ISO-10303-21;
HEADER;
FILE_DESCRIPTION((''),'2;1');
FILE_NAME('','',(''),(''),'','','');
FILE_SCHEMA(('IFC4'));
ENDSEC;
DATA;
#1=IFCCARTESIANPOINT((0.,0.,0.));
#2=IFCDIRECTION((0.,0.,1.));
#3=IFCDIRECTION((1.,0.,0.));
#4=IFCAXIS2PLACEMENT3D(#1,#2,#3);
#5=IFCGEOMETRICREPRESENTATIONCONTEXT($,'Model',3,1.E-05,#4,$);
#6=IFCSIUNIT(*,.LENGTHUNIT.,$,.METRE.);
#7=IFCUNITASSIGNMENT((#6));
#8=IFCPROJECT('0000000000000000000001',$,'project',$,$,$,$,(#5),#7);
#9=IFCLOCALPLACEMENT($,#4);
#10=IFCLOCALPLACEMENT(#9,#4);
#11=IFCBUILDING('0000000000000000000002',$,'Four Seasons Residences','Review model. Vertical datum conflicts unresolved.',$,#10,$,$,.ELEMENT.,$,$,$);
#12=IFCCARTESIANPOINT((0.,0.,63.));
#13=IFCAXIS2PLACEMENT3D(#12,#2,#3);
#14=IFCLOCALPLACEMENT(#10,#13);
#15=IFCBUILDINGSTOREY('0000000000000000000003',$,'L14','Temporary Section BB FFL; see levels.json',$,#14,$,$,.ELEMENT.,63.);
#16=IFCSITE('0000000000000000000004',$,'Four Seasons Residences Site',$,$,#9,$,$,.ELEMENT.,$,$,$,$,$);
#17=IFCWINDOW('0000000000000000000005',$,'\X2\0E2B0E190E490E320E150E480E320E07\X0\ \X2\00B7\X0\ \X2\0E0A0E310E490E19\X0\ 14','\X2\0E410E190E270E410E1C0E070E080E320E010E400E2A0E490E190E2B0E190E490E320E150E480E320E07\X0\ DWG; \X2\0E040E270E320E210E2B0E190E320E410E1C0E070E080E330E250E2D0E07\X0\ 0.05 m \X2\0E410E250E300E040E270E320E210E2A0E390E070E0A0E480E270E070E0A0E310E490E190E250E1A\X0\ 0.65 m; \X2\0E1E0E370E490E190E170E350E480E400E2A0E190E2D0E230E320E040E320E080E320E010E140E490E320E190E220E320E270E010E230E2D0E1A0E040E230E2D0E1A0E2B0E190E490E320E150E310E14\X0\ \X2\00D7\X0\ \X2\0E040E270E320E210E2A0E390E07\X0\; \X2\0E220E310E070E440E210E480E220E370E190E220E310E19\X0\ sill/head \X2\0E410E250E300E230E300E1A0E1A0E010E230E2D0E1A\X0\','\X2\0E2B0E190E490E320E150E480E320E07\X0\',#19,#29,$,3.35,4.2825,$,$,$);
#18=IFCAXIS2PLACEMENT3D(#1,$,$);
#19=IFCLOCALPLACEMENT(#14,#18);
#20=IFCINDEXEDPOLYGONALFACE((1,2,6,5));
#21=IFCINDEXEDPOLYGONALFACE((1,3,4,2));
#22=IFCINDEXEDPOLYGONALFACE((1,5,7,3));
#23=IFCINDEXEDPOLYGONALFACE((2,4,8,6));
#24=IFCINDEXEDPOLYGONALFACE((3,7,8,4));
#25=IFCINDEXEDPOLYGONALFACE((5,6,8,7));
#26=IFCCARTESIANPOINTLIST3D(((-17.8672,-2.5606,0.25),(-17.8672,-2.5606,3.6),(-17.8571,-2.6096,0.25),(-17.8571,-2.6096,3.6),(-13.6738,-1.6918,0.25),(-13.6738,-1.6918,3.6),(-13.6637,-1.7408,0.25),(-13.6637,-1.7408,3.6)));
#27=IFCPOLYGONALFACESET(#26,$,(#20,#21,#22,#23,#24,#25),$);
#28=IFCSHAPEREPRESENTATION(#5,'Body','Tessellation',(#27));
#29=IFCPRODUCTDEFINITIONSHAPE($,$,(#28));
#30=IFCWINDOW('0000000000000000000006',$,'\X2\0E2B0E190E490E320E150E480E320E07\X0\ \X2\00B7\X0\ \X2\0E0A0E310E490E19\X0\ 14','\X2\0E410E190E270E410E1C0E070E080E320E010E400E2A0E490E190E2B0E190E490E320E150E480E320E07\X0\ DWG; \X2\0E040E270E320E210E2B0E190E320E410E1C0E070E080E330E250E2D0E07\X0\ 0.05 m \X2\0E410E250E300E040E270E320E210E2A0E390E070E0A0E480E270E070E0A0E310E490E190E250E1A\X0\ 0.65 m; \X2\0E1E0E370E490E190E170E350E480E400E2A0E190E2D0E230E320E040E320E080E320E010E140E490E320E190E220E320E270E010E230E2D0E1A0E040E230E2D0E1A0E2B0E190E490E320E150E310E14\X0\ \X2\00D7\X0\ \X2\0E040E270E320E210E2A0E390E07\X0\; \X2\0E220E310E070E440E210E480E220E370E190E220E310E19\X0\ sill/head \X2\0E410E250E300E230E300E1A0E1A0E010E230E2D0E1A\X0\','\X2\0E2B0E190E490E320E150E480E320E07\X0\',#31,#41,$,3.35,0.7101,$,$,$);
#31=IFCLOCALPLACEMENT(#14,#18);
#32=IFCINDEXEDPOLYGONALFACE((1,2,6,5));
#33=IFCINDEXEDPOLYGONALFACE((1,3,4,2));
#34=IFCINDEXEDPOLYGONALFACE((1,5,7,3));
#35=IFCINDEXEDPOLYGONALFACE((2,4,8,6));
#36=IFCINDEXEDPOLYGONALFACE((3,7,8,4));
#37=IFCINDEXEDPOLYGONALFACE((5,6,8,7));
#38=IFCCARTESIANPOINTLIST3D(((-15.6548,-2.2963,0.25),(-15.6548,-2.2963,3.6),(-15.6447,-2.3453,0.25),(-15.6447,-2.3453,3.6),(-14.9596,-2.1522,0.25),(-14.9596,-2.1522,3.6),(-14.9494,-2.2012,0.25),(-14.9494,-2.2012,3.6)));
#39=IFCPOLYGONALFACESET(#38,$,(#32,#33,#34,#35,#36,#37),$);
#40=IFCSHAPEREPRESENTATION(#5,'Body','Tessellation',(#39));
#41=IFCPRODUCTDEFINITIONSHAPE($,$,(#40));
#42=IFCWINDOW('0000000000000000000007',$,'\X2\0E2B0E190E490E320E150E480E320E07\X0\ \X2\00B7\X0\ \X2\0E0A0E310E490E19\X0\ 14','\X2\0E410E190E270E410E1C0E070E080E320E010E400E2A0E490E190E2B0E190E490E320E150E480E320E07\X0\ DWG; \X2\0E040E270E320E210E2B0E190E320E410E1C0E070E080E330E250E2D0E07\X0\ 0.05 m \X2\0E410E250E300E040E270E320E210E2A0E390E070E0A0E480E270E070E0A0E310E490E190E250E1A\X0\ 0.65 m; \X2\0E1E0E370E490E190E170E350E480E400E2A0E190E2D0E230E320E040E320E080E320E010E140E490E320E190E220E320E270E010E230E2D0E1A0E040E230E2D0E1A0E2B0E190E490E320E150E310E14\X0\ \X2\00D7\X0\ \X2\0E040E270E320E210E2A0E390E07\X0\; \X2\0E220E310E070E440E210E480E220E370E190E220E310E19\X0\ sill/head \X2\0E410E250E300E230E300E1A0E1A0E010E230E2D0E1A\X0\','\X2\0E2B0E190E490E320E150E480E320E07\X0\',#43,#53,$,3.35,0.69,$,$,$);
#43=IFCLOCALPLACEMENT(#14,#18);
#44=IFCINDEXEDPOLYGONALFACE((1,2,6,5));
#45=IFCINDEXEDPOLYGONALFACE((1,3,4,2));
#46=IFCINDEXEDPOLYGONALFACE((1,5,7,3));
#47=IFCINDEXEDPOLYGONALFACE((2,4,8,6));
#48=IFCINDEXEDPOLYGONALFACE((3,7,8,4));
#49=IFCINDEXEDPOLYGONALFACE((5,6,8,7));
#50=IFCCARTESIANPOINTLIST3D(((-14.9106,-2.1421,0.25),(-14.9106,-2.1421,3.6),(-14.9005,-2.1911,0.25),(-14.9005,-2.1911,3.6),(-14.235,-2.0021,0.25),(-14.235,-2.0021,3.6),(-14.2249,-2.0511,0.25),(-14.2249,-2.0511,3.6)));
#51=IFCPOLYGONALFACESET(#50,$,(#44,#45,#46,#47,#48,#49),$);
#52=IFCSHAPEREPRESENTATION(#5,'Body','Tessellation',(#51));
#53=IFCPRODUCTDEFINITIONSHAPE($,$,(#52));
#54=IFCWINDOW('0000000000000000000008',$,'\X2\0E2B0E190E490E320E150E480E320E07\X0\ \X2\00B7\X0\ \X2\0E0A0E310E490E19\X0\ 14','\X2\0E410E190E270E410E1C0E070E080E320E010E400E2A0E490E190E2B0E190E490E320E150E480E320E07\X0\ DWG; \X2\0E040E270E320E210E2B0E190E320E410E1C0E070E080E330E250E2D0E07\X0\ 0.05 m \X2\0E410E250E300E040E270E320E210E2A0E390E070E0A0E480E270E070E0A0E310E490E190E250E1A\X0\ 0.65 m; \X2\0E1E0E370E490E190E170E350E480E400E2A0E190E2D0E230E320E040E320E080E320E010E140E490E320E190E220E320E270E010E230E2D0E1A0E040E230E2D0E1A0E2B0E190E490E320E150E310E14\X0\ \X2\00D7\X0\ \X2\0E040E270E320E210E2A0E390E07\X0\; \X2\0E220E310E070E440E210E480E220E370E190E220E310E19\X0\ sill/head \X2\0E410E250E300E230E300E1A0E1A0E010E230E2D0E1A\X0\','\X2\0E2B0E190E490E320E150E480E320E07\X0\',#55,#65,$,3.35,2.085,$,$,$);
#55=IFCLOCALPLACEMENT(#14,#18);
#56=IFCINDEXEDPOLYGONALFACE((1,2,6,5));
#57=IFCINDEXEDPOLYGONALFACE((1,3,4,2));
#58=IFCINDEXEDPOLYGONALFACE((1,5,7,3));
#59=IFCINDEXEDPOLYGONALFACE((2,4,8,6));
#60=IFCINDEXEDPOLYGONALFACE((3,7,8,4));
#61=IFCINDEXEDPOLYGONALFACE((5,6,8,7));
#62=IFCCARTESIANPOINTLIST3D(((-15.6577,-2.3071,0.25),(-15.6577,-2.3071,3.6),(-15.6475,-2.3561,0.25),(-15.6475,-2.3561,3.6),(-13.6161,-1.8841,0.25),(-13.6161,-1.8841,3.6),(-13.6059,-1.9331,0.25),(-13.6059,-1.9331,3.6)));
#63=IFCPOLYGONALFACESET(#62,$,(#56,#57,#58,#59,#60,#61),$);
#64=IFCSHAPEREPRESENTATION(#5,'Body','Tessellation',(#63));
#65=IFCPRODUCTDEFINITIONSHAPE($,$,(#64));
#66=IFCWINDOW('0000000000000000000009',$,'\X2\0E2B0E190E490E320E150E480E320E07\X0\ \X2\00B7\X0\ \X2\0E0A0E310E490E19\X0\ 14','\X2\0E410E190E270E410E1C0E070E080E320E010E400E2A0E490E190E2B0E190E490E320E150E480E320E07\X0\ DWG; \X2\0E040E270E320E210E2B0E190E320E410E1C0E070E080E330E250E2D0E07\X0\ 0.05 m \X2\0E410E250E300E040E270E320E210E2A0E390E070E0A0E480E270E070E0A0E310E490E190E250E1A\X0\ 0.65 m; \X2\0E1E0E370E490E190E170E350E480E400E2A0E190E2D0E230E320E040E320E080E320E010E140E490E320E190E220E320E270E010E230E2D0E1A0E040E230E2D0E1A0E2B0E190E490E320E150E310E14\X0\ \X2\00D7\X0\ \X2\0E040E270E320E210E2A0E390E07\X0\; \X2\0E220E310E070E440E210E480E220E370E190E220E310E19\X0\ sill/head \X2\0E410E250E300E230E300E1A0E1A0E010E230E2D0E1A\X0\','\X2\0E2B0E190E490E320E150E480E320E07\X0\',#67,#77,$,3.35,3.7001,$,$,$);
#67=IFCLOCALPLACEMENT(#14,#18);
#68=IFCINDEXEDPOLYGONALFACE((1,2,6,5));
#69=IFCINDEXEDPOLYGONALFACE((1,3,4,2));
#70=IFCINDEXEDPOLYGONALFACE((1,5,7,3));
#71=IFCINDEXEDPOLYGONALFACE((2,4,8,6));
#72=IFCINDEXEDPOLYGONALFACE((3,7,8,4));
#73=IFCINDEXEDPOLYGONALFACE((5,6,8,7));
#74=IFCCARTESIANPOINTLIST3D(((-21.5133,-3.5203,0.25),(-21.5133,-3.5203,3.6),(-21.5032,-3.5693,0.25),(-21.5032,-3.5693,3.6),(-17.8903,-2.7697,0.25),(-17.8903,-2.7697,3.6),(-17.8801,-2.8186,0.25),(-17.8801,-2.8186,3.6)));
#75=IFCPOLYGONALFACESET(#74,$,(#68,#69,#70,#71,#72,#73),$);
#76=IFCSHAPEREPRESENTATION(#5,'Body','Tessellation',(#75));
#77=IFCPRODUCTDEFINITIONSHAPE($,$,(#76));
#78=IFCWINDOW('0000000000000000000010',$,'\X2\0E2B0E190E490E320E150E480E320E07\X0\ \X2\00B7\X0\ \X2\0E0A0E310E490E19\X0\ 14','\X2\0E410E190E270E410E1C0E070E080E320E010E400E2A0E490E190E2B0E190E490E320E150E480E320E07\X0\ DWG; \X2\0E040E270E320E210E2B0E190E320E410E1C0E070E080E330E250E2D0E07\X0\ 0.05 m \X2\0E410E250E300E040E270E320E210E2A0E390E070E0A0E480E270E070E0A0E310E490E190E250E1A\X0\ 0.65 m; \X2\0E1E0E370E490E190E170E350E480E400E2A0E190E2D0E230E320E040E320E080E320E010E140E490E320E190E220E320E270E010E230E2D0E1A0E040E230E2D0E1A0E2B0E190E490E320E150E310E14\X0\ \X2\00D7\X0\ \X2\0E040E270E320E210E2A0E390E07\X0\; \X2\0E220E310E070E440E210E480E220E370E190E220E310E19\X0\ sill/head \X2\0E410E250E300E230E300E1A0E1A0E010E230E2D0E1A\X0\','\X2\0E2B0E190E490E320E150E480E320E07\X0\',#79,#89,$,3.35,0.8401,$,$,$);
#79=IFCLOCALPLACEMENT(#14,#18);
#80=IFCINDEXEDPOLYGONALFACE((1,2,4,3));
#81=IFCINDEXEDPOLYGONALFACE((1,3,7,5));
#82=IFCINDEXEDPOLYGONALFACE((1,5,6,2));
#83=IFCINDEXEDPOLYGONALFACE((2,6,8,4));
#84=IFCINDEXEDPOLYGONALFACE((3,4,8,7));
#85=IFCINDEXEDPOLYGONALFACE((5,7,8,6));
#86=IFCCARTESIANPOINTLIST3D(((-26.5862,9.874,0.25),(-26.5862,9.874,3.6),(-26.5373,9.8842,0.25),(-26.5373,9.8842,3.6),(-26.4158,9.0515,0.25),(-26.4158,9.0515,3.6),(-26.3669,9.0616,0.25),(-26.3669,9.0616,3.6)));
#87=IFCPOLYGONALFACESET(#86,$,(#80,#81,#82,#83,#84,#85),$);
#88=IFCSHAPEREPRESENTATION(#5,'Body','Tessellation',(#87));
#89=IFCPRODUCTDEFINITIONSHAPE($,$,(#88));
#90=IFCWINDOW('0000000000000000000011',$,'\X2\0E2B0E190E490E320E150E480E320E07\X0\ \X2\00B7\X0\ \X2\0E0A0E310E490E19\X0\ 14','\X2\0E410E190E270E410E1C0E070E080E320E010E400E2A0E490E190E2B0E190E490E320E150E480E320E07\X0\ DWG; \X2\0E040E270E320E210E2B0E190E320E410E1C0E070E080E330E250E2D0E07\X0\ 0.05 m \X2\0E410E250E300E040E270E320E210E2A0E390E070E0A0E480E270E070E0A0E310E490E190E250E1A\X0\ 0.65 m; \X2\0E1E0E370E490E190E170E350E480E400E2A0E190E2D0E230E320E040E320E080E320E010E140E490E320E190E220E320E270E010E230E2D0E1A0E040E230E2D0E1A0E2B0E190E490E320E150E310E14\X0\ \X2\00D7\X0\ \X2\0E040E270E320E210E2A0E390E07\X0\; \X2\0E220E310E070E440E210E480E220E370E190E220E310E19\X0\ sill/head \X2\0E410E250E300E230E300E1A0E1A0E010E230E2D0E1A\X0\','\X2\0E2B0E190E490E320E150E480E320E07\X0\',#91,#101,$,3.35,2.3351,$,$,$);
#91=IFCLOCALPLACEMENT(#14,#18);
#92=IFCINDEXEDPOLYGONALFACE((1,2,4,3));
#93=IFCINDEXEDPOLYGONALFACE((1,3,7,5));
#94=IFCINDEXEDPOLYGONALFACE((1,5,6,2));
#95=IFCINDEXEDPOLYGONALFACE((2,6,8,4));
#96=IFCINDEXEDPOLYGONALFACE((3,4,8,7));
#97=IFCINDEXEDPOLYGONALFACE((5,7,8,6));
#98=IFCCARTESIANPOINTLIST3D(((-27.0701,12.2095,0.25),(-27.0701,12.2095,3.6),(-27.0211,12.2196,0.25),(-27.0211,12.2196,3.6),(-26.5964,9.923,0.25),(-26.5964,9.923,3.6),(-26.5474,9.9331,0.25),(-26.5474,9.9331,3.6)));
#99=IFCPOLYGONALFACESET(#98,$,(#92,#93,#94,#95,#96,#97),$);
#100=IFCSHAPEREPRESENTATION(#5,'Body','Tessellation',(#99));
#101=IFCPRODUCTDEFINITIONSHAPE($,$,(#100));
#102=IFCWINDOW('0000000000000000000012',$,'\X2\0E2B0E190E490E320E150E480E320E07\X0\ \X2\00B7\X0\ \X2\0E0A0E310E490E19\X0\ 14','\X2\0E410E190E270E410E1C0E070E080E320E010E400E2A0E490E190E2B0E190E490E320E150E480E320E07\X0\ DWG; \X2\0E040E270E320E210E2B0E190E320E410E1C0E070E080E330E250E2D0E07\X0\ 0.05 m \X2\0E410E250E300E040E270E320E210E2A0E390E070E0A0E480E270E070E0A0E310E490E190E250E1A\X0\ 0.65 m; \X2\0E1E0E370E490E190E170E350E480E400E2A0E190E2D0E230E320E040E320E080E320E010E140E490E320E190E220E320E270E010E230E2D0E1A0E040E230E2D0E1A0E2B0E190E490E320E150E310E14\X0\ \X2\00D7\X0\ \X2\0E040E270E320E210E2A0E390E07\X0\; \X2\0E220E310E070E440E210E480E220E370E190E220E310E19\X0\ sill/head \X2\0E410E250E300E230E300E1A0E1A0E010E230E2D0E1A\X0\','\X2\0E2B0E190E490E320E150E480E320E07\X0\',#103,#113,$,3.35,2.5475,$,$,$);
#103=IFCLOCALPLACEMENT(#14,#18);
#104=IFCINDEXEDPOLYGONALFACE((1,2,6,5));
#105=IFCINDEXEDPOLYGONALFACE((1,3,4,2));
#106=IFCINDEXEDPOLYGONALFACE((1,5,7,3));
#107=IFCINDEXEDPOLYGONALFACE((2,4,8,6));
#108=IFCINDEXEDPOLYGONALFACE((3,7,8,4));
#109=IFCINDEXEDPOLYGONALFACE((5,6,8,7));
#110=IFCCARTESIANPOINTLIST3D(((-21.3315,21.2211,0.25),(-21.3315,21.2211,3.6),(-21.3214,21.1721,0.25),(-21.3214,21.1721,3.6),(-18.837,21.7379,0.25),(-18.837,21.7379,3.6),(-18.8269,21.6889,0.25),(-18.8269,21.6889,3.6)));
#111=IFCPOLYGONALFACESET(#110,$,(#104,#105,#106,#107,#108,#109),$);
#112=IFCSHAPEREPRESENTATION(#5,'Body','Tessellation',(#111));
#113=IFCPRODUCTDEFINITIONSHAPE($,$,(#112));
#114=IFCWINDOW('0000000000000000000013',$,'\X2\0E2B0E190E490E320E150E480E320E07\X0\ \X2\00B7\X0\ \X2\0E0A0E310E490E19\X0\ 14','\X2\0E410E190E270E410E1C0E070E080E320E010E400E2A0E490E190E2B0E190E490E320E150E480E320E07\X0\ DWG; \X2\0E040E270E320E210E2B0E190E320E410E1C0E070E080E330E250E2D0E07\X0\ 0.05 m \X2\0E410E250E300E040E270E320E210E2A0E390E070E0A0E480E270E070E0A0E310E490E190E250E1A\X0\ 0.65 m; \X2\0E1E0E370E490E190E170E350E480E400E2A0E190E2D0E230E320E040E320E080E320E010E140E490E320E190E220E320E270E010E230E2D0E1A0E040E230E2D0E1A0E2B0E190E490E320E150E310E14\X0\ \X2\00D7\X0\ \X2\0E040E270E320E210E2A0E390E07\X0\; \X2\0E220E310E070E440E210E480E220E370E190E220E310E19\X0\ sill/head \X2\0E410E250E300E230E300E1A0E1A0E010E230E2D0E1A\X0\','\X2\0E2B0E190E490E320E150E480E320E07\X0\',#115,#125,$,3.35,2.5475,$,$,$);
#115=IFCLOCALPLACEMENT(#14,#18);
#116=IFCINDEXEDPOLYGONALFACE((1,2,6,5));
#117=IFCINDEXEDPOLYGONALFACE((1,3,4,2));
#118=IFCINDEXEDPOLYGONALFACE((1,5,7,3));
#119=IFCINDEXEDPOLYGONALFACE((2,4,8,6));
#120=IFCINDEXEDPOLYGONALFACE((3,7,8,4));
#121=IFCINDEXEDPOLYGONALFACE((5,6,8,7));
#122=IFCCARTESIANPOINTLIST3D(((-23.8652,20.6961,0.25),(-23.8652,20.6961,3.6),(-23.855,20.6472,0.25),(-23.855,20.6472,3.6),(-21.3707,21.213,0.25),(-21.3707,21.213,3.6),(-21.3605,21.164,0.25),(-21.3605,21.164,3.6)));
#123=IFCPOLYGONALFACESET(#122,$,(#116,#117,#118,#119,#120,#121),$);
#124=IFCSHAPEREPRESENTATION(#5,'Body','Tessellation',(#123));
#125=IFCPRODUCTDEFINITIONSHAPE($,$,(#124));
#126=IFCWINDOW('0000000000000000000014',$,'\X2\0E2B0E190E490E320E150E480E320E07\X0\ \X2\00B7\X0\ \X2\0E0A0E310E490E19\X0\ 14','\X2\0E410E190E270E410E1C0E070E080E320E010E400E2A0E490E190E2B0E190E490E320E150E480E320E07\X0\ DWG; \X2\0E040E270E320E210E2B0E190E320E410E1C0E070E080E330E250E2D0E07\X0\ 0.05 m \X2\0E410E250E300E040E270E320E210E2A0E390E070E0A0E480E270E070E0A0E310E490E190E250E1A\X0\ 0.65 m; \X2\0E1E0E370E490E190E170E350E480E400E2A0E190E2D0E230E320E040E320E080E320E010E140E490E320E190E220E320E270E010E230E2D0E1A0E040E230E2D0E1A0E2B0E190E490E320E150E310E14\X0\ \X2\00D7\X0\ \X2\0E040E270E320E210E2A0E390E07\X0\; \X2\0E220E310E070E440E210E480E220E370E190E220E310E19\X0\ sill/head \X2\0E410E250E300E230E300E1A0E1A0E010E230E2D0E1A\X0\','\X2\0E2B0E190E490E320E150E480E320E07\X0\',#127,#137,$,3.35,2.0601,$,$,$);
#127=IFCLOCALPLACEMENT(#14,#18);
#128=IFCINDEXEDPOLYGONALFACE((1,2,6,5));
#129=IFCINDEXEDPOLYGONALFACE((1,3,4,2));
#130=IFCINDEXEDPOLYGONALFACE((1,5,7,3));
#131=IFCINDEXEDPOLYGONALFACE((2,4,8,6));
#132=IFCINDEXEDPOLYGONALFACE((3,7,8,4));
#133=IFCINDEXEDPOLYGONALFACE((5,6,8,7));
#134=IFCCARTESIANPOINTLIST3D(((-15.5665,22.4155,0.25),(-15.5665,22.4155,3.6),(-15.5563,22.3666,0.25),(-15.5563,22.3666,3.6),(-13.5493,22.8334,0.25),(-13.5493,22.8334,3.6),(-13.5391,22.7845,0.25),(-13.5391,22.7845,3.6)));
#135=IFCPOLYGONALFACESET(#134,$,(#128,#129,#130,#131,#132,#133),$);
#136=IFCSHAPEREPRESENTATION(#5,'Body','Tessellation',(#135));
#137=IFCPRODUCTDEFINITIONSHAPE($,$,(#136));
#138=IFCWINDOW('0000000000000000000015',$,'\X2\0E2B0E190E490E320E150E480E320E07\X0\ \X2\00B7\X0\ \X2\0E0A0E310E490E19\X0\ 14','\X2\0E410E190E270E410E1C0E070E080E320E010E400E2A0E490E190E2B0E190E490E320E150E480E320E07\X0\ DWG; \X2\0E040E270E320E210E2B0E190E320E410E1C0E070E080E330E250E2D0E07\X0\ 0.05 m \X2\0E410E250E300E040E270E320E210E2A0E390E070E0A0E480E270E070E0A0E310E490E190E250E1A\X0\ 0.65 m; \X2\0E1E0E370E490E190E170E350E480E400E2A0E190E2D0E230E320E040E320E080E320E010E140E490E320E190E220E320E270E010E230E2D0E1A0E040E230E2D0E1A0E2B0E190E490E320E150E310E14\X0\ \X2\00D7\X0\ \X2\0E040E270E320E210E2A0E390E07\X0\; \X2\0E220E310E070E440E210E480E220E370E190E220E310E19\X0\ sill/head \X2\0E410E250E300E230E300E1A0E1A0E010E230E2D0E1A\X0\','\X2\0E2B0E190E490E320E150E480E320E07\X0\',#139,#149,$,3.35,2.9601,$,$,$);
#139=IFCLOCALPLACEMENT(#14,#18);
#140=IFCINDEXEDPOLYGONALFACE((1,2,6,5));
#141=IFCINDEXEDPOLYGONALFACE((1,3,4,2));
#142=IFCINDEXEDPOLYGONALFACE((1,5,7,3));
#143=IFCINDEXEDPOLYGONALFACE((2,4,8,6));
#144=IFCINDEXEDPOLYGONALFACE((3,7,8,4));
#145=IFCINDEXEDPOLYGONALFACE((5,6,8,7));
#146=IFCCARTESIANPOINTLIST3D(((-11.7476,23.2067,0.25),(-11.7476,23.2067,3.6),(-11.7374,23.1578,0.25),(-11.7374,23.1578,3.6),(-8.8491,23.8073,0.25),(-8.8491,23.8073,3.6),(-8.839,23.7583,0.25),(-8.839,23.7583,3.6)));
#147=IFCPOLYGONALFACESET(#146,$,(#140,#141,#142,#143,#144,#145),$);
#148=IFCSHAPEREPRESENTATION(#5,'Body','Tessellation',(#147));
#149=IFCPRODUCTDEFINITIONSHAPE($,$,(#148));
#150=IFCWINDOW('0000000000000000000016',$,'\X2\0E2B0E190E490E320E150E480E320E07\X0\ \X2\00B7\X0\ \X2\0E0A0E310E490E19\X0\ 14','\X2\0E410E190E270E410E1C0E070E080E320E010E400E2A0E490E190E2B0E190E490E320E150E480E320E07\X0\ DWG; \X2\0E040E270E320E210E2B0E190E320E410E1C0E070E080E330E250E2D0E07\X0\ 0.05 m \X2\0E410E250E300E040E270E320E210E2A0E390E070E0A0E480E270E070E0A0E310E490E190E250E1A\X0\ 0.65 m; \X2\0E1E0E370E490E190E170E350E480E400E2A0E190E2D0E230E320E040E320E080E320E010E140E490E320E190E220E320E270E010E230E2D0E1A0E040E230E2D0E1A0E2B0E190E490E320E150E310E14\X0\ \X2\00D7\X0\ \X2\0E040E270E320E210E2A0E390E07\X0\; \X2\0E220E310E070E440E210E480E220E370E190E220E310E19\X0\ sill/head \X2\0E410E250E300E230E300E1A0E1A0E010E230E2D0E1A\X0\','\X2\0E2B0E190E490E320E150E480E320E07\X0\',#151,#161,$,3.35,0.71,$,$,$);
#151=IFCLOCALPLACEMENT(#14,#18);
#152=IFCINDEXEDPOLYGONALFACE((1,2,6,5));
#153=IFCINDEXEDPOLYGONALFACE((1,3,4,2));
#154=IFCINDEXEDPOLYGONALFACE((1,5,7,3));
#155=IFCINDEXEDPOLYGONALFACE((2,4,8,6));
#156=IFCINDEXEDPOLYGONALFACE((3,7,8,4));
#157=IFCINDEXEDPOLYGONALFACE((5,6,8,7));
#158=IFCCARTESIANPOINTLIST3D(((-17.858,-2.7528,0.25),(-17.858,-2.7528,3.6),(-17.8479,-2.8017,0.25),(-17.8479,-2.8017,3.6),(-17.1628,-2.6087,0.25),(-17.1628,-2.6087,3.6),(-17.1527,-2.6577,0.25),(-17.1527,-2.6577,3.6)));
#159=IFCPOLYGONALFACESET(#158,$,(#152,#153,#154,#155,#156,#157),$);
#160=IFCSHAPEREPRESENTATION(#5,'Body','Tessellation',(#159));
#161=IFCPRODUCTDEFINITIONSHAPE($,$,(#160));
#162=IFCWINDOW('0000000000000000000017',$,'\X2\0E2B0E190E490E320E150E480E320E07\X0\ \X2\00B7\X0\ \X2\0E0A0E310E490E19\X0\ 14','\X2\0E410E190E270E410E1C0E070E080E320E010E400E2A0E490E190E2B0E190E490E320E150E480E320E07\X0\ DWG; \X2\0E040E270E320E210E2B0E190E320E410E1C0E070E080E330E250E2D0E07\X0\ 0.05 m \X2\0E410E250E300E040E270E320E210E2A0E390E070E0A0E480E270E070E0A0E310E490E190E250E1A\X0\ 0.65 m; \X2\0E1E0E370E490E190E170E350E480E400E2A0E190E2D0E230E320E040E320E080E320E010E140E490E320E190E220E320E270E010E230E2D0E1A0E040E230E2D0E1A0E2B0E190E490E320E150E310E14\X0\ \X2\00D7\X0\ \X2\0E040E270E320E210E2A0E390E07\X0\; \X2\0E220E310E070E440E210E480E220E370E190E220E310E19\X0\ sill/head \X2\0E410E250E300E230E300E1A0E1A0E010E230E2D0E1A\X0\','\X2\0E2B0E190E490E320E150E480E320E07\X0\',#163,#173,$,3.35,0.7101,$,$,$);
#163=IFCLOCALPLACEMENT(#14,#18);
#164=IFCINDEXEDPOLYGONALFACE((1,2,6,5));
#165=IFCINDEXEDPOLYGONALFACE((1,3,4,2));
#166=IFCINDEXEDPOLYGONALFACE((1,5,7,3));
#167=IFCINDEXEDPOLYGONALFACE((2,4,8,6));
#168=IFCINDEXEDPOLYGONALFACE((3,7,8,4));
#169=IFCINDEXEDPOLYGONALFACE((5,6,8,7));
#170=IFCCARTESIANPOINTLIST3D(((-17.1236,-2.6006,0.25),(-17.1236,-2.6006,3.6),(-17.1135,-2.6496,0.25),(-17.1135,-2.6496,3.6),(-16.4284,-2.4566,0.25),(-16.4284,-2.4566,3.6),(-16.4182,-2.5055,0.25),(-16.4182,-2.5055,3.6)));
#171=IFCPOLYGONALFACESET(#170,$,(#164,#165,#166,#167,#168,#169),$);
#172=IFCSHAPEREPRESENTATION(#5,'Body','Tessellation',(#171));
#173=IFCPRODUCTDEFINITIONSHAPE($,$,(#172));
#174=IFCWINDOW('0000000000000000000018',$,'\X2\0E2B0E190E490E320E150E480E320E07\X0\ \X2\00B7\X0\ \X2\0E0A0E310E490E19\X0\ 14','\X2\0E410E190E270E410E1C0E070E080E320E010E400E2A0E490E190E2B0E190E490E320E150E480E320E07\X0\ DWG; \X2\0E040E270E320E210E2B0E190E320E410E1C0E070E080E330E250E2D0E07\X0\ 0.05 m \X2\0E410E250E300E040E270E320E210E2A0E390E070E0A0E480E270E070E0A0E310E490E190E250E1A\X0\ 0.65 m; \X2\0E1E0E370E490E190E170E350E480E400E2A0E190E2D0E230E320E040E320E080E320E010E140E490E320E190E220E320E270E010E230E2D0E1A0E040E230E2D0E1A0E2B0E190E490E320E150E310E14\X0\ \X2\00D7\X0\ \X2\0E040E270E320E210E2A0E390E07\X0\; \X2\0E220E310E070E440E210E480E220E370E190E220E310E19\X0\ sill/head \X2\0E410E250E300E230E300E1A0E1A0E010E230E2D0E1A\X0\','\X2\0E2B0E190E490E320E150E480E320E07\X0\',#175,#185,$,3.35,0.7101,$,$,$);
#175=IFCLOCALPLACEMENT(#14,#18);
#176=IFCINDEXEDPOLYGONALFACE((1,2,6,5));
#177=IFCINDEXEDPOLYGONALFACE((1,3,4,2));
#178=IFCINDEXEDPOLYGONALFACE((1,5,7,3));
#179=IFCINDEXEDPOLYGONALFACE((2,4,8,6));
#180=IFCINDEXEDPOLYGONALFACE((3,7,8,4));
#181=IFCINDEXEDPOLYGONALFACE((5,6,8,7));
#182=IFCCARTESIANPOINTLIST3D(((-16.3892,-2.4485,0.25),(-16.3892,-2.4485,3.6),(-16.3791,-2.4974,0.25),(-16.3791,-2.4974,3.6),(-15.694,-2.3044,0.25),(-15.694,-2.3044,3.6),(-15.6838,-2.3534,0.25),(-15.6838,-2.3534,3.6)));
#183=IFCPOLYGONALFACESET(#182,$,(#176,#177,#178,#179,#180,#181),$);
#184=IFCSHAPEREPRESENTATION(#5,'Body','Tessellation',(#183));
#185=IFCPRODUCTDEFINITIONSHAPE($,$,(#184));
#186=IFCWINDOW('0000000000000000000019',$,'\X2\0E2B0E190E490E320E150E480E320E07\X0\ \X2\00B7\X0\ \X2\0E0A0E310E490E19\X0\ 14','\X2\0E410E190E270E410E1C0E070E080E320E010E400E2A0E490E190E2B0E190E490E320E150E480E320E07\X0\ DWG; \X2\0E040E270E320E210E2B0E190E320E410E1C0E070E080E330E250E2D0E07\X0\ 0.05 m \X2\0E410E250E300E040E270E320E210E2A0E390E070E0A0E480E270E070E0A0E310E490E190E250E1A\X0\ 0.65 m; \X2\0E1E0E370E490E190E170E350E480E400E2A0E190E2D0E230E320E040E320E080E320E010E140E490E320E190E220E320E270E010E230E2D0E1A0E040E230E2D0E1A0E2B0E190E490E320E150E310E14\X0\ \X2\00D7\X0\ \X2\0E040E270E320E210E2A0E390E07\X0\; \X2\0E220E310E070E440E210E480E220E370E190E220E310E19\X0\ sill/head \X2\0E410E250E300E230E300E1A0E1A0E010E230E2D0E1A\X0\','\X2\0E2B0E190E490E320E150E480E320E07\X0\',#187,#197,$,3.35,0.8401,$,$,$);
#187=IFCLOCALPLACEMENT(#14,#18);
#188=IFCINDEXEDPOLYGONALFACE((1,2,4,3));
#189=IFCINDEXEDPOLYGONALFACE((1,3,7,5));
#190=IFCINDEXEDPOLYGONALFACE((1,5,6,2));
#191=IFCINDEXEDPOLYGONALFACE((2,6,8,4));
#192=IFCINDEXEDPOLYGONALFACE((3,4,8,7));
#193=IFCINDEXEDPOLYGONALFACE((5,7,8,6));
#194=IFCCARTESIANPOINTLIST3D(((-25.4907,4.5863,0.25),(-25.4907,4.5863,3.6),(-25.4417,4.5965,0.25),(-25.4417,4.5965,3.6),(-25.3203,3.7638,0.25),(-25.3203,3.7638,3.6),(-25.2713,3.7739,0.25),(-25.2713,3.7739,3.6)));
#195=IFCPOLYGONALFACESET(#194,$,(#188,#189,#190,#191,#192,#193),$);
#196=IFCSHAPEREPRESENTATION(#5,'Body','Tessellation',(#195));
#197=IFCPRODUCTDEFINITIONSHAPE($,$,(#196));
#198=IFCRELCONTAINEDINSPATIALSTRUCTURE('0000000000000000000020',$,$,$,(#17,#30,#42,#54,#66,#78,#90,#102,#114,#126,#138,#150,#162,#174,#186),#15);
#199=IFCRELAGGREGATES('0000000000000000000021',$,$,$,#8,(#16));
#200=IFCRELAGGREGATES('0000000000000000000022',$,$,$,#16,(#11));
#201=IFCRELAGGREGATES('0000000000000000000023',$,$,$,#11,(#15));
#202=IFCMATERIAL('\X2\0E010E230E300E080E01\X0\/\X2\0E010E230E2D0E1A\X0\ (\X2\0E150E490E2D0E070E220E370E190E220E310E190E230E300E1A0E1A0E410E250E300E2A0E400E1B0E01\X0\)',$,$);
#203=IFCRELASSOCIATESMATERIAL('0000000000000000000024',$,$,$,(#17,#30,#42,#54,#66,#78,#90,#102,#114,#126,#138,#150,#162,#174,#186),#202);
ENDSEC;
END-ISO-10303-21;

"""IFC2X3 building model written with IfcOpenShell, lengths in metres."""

from ifc_helpers import new_model, si_unit, frame, origin_with_axes, place, context, project, spatial, polyline, outline, extrude, material, element, save


model = new_model("IFC2X3")

# Units and contexts
model_context = context("Model", 3, precision=1e-05, world=origin_with_axes())
ifc_project = project(units=[si_unit("LENGTHUNIT", "METRE")], contexts=[model_context])

# Site, building, storey
site_placement = place(None, origin_with_axes())
site = spatial("IfcSite", under=ifc_project, at=site_placement, Name="Four Seasons Residences Site", CompositionType="ELEMENT")
building_placement = place(site_placement, origin_with_axes())
building = spatial("IfcBuilding", under=site, at=building_placement, Name="Four Seasons Residences", Description="Review model. Vertical datum conflicts unresolved.", CompositionType="ELEMENT")
storey_placement = place(building_placement, frame((0.0, 0.0, 63.0), z_axis=(0.0, 0.0, 1.0), x_axis=(1.0, 0.0, 0.0)))
storey = spatial("IfcBuildingStorey", under=building, at=storey_placement, Name="L14", Description="Temporary Section BB FFL; see levels.json", CompositionType="ELEMENT", Elevation=63.0)

# Windows
ifc_material = material(Name="กระจก/กรอบ (ต้องยืนยันระบบและสเปก)")
window_1_placement = place(storey_placement, origin_with_axes())
element("IfcWindow", 1, at=window_1_placement, inside=storey, material=ifc_material, Name="หน้าต่าง · ชั้น 14", Description="แนวแผงจากเส้นหน้าต่าง DWG; ความหนาแผงจำลอง 0.05 m และความสูงช่วงชั้นลบ 0.65 m; พื้นที่เสนอราคาจากด้านยาวกรอบครอบหน้าตัด × ความสูง; ยังไม่ยืนยัน sill/head และระบบกรอบ", ObjectType="หน้าต่าง", OverallHeight=3.35, OverallWidth=4.2825, context=model_context, shape_type="SweptSolid", body=[
    extrude(outline(polyline([(-13.6738, -1.6918), (-13.6637, -1.7408), (-17.8571, -2.6096), (-17.8672, -2.5606), (-13.6738, -1.6918)])), frame((0.0, 0.0, 0.25), z_axis=(0.0, 0.0, 1.0), x_axis=(1.0, 0.0, 0.0)), (0.0, 0.0, 1.0), 3.35),
])
window_2_placement = place(storey_placement, origin_with_axes())
element("IfcWindow", 2, at=window_2_placement, inside=storey, material=ifc_material, Name="หน้าต่าง · ชั้น 14", Description="แนวแผงจากเส้นหน้าต่าง DWG; ความหนาแผงจำลอง 0.05 m และความสูงช่วงชั้นลบ 0.65 m; พื้นที่เสนอราคาจากด้านยาวกรอบครอบหน้าตัด × ความสูง; ยังไม่ยืนยัน sill/head และระบบกรอบ", ObjectType="หน้าต่าง", OverallHeight=3.35, OverallWidth=0.7101, context=model_context, shape_type="SweptSolid", body=[
    extrude(outline(polyline([(-14.9596, -2.1522), (-14.9494, -2.2012), (-15.6447, -2.3453), (-15.6548, -2.2963), (-14.9596, -2.1522)])), frame((0.0, 0.0, 0.25), z_axis=(0.0, 0.0, 1.0), x_axis=(1.0, 0.0, 0.0)), (0.0, 0.0, 1.0), 3.35),
])
window_3_placement = place(storey_placement, origin_with_axes())
element("IfcWindow", 3, at=window_3_placement, inside=storey, material=ifc_material, Name="หน้าต่าง · ชั้น 14", Description="แนวแผงจากเส้นหน้าต่าง DWG; ความหนาแผงจำลอง 0.05 m และความสูงช่วงชั้นลบ 0.65 m; พื้นที่เสนอราคาจากด้านยาวกรอบครอบหน้าตัด × ความสูง; ยังไม่ยืนยัน sill/head และระบบกรอบ", ObjectType="หน้าต่าง", OverallHeight=3.35, OverallWidth=0.69, context=model_context, shape_type="SweptSolid", body=[
    extrude(outline(polyline([(-14.235, -2.0021), (-14.2249, -2.0511), (-14.9005, -2.1911), (-14.9106, -2.1421), (-14.235, -2.0021)])), frame((0.0, 0.0, 0.25), z_axis=(0.0, 0.0, 1.0), x_axis=(1.0, 0.0, 0.0)), (0.0, 0.0, 1.0), 3.35),
])
window_4_placement = place(storey_placement, origin_with_axes())
element("IfcWindow", 4, at=window_4_placement, inside=storey, material=ifc_material, Name="หน้าต่าง · ชั้น 14", Description="แนวแผงจากเส้นหน้าต่าง DWG; ความหนาแผงจำลอง 0.05 m และความสูงช่วงชั้นลบ 0.65 m; พื้นที่เสนอราคาจากด้านยาวกรอบครอบหน้าตัด × ความสูง; ยังไม่ยืนยัน sill/head และระบบกรอบ", ObjectType="หน้าต่าง", OverallHeight=3.35, OverallWidth=2.085, context=model_context, shape_type="SweptSolid", body=[
    extrude(outline(polyline([(-13.6161, -1.8841), (-13.6059, -1.9331), (-15.6475, -2.3561), (-15.6577, -2.3071), (-13.6161, -1.8841)])), frame((0.0, 0.0, 0.25), z_axis=(0.0, 0.0, 1.0), x_axis=(1.0, 0.0, 0.0)), (0.0, 0.0, 1.0), 3.35),
])
window_5_placement = place(storey_placement, origin_with_axes())
element("IfcWindow", 5, at=window_5_placement, inside=storey, material=ifc_material, Name="หน้าต่าง · ชั้น 14", Description="แนวแผงจากเส้นหน้าต่าง DWG; ความหนาแผงจำลอง 0.05 m และความสูงช่วงชั้นลบ 0.65 m; พื้นที่เสนอราคาจากด้านยาวกรอบครอบหน้าตัด × ความสูง; ยังไม่ยืนยัน sill/head และระบบกรอบ", ObjectType="หน้าต่าง", OverallHeight=3.35, OverallWidth=3.7001, context=model_context, shape_type="SweptSolid", body=[
    extrude(outline(polyline([(-17.8903, -2.7697), (-17.8801, -2.8186), (-21.5032, -3.5693), (-21.5133, -3.5203), (-17.8903, -2.7697)])), frame((0.0, 0.0, 0.25), z_axis=(0.0, 0.0, 1.0), x_axis=(1.0, 0.0, 0.0)), (0.0, 0.0, 1.0), 3.35),
])
window_6_placement = place(storey_placement, origin_with_axes())
element("IfcWindow", 6, at=window_6_placement, inside=storey, material=ifc_material, Name="หน้าต่าง · ชั้น 14", Description="แนวแผงจากเส้นหน้าต่าง DWG; ความหนาแผงจำลอง 0.05 m และความสูงช่วงชั้นลบ 0.65 m; พื้นที่เสนอราคาจากด้านยาวกรอบครอบหน้าตัด × ความสูง; ยังไม่ยืนยัน sill/head และระบบกรอบ", ObjectType="หน้าต่าง", OverallHeight=3.35, OverallWidth=0.8401, context=model_context, shape_type="SweptSolid", body=[
    extrude(outline(polyline([(-26.3669, 9.0616), (-26.4158, 9.0515), (-26.5862, 9.874), (-26.5373, 9.8842), (-26.3669, 9.0616)])), frame((0.0, 0.0, 0.25), z_axis=(0.0, 0.0, 1.0), x_axis=(1.0, 0.0, 0.0)), (0.0, 0.0, 1.0), 3.35),
])
window_7_placement = place(storey_placement, origin_with_axes())
element("IfcWindow", 7, at=window_7_placement, inside=storey, material=ifc_material, Name="หน้าต่าง · ชั้น 14", Description="แนวแผงจากเส้นหน้าต่าง DWG; ความหนาแผงจำลอง 0.05 m และความสูงช่วงชั้นลบ 0.65 m; พื้นที่เสนอราคาจากด้านยาวกรอบครอบหน้าตัด × ความสูง; ยังไม่ยืนยัน sill/head และระบบกรอบ", ObjectType="หน้าต่าง", OverallHeight=3.35, OverallWidth=2.3351, context=model_context, shape_type="SweptSolid", body=[
    extrude(outline(polyline([(-26.5474, 9.9331), (-26.5964, 9.923), (-27.0701, 12.2095), (-27.0211, 12.2196), (-26.5474, 9.9331)])), frame((0.0, 0.0, 0.25), z_axis=(0.0, 0.0, 1.0), x_axis=(1.0, 0.0, 0.0)), (0.0, 0.0, 1.0), 3.35),
])
window_8_placement = place(storey_placement, origin_with_axes())
element("IfcWindow", 8, at=window_8_placement, inside=storey, material=ifc_material, Name="หน้าต่าง · ชั้น 14", Description="แนวแผงจากเส้นหน้าต่าง DWG; ความหนาแผงจำลอง 0.05 m และความสูงช่วงชั้นลบ 0.65 m; พื้นที่เสนอราคาจากด้านยาวกรอบครอบหน้าตัด × ความสูง; ยังไม่ยืนยัน sill/head และระบบกรอบ", ObjectType="หน้าต่าง", OverallHeight=3.35, OverallWidth=2.5475, context=model_context, shape_type="SweptSolid", body=[
    extrude(outline(polyline([(-18.837, 21.7379), (-18.8269, 21.6889), (-21.3214, 21.1721), (-21.3315, 21.2211), (-18.837, 21.7379)])), frame((0.0, 0.0, 0.25), z_axis=(0.0, 0.0, 1.0), x_axis=(1.0, 0.0, 0.0)), (0.0, 0.0, 1.0), 3.35),
])
window_9_placement = place(storey_placement, origin_with_axes())
element("IfcWindow", 9, at=window_9_placement, inside=storey, material=ifc_material, Name="หน้าต่าง · ชั้น 14", Description="แนวแผงจากเส้นหน้าต่าง DWG; ความหนาแผงจำลอง 0.05 m และความสูงช่วงชั้นลบ 0.65 m; พื้นที่เสนอราคาจากด้านยาวกรอบครอบหน้าตัด × ความสูง; ยังไม่ยืนยัน sill/head และระบบกรอบ", ObjectType="หน้าต่าง", OverallHeight=3.35, OverallWidth=2.5475, context=model_context, shape_type="SweptSolid", body=[
    extrude(outline(polyline([(-21.3707, 21.213), (-21.3605, 21.164), (-23.855, 20.6472), (-23.8652, 20.6961), (-21.3707, 21.213)])), frame((0.0, 0.0, 0.25), z_axis=(0.0, 0.0, 1.0), x_axis=(1.0, 0.0, 0.0)), (0.0, 0.0, 1.0), 3.35),
])
window_10_placement = place(storey_placement, origin_with_axes())
element("IfcWindow", 10, at=window_10_placement, inside=storey, material=ifc_material, Name="หน้าต่าง · ชั้น 14", Description="แนวแผงจากเส้นหน้าต่าง DWG; ความหนาแผงจำลอง 0.05 m และความสูงช่วงชั้นลบ 0.65 m; พื้นที่เสนอราคาจากด้านยาวกรอบครอบหน้าตัด × ความสูง; ยังไม่ยืนยัน sill/head และระบบกรอบ", ObjectType="หน้าต่าง", OverallHeight=3.35, OverallWidth=2.0601, context=model_context, shape_type="SweptSolid", body=[
    extrude(outline(polyline([(-13.5493, 22.8334), (-13.5391, 22.7845), (-15.5563, 22.3666), (-15.5665, 22.4155), (-13.5493, 22.8334)])), frame((0.0, 0.0, 0.25), z_axis=(0.0, 0.0, 1.0), x_axis=(1.0, 0.0, 0.0)), (0.0, 0.0, 1.0), 3.35),
])
window_11_placement = place(storey_placement, origin_with_axes())
element("IfcWindow", 11, at=window_11_placement, inside=storey, material=ifc_material, Name="หน้าต่าง · ชั้น 14", Description="แนวแผงจากเส้นหน้าต่าง DWG; ความหนาแผงจำลอง 0.05 m และความสูงช่วงชั้นลบ 0.65 m; พื้นที่เสนอราคาจากด้านยาวกรอบครอบหน้าตัด × ความสูง; ยังไม่ยืนยัน sill/head และระบบกรอบ", ObjectType="หน้าต่าง", OverallHeight=3.35, OverallWidth=2.9601, context=model_context, shape_type="SweptSolid", body=[
    extrude(outline(polyline([(-8.8491, 23.8073), (-8.839, 23.7583), (-11.7374, 23.1578), (-11.7476, 23.2067), (-8.8491, 23.8073)])), frame((0.0, 0.0, 0.25), z_axis=(0.0, 0.0, 1.0), x_axis=(1.0, 0.0, 0.0)), (0.0, 0.0, 1.0), 3.35),
])
window_12_placement = place(storey_placement, origin_with_axes())
element("IfcWindow", 12, at=window_12_placement, inside=storey, material=ifc_material, Name="หน้าต่าง · ชั้น 14", Description="แนวแผงจากเส้นหน้าต่าง DWG; ความหนาแผงจำลอง 0.05 m และความสูงช่วงชั้นลบ 0.65 m; พื้นที่เสนอราคาจากด้านยาวกรอบครอบหน้าตัด × ความสูง; ยังไม่ยืนยัน sill/head และระบบกรอบ", ObjectType="หน้าต่าง", OverallHeight=3.35, OverallWidth=0.71, context=model_context, shape_type="SweptSolid", body=[
    extrude(outline(polyline([(-17.1628, -2.6087), (-17.1527, -2.6577), (-17.8479, -2.8017), (-17.858, -2.7528), (-17.1628, -2.6087)])), frame((0.0, 0.0, 0.25), z_axis=(0.0, 0.0, 1.0), x_axis=(1.0, 0.0, 0.0)), (0.0, 0.0, 1.0), 3.35),
])
window_13_placement = place(storey_placement, origin_with_axes())
element("IfcWindow", 13, at=window_13_placement, inside=storey, material=ifc_material, Name="หน้าต่าง · ชั้น 14", Description="แนวแผงจากเส้นหน้าต่าง DWG; ความหนาแผงจำลอง 0.05 m และความสูงช่วงชั้นลบ 0.65 m; พื้นที่เสนอราคาจากด้านยาวกรอบครอบหน้าตัด × ความสูง; ยังไม่ยืนยัน sill/head และระบบกรอบ", ObjectType="หน้าต่าง", OverallHeight=3.35, OverallWidth=0.7101, context=model_context, shape_type="SweptSolid", body=[
    extrude(outline(polyline([(-16.4284, -2.4566), (-16.4182, -2.5055), (-17.1135, -2.6496), (-17.1236, -2.6006), (-16.4284, -2.4566)])), frame((0.0, 0.0, 0.25), z_axis=(0.0, 0.0, 1.0), x_axis=(1.0, 0.0, 0.0)), (0.0, 0.0, 1.0), 3.35),
])
window_14_placement = place(storey_placement, origin_with_axes())
element("IfcWindow", 14, at=window_14_placement, inside=storey, material=ifc_material, Name="หน้าต่าง · ชั้น 14", Description="แนวแผงจากเส้นหน้าต่าง DWG; ความหนาแผงจำลอง 0.05 m และความสูงช่วงชั้นลบ 0.65 m; พื้นที่เสนอราคาจากด้านยาวกรอบครอบหน้าตัด × ความสูง; ยังไม่ยืนยัน sill/head และระบบกรอบ", ObjectType="หน้าต่าง", OverallHeight=3.35, OverallWidth=0.7101, context=model_context, shape_type="SweptSolid", body=[
    extrude(outline(polyline([(-15.694, -2.3044), (-15.6838, -2.3534), (-16.3791, -2.4974), (-16.3892, -2.4485), (-15.694, -2.3044)])), frame((0.0, 0.0, 0.25), z_axis=(0.0, 0.0, 1.0), x_axis=(1.0, 0.0, 0.0)), (0.0, 0.0, 1.0), 3.35),
])
window_15_placement = place(storey_placement, origin_with_axes())
element("IfcWindow", 15, at=window_15_placement, inside=storey, material=ifc_material, Name="หน้าต่าง · ชั้น 14", Description="แนวแผงจากเส้นหน้าต่าง DWG; ความหนาแผงจำลอง 0.05 m และความสูงช่วงชั้นลบ 0.65 m; พื้นที่เสนอราคาจากด้านยาวกรอบครอบหน้าตัด × ความสูง; ยังไม่ยืนยัน sill/head และระบบกรอบ", ObjectType="หน้าต่าง", OverallHeight=3.35, OverallWidth=0.8401, context=model_context, shape_type="SweptSolid", body=[
    extrude(outline(polyline([(-25.2713, 3.7739), (-25.3203, 3.7638), (-25.4907, 4.5863), (-25.4417, 4.5965), (-25.2713, 3.7739)])), frame((0.0, 0.0, 0.25), z_axis=(0.0, 0.0, 1.0), x_axis=(1.0, 0.0, 0.0)), (0.0, 0.0, 1.0), 3.35),
])

save(model, "model.ifc")
